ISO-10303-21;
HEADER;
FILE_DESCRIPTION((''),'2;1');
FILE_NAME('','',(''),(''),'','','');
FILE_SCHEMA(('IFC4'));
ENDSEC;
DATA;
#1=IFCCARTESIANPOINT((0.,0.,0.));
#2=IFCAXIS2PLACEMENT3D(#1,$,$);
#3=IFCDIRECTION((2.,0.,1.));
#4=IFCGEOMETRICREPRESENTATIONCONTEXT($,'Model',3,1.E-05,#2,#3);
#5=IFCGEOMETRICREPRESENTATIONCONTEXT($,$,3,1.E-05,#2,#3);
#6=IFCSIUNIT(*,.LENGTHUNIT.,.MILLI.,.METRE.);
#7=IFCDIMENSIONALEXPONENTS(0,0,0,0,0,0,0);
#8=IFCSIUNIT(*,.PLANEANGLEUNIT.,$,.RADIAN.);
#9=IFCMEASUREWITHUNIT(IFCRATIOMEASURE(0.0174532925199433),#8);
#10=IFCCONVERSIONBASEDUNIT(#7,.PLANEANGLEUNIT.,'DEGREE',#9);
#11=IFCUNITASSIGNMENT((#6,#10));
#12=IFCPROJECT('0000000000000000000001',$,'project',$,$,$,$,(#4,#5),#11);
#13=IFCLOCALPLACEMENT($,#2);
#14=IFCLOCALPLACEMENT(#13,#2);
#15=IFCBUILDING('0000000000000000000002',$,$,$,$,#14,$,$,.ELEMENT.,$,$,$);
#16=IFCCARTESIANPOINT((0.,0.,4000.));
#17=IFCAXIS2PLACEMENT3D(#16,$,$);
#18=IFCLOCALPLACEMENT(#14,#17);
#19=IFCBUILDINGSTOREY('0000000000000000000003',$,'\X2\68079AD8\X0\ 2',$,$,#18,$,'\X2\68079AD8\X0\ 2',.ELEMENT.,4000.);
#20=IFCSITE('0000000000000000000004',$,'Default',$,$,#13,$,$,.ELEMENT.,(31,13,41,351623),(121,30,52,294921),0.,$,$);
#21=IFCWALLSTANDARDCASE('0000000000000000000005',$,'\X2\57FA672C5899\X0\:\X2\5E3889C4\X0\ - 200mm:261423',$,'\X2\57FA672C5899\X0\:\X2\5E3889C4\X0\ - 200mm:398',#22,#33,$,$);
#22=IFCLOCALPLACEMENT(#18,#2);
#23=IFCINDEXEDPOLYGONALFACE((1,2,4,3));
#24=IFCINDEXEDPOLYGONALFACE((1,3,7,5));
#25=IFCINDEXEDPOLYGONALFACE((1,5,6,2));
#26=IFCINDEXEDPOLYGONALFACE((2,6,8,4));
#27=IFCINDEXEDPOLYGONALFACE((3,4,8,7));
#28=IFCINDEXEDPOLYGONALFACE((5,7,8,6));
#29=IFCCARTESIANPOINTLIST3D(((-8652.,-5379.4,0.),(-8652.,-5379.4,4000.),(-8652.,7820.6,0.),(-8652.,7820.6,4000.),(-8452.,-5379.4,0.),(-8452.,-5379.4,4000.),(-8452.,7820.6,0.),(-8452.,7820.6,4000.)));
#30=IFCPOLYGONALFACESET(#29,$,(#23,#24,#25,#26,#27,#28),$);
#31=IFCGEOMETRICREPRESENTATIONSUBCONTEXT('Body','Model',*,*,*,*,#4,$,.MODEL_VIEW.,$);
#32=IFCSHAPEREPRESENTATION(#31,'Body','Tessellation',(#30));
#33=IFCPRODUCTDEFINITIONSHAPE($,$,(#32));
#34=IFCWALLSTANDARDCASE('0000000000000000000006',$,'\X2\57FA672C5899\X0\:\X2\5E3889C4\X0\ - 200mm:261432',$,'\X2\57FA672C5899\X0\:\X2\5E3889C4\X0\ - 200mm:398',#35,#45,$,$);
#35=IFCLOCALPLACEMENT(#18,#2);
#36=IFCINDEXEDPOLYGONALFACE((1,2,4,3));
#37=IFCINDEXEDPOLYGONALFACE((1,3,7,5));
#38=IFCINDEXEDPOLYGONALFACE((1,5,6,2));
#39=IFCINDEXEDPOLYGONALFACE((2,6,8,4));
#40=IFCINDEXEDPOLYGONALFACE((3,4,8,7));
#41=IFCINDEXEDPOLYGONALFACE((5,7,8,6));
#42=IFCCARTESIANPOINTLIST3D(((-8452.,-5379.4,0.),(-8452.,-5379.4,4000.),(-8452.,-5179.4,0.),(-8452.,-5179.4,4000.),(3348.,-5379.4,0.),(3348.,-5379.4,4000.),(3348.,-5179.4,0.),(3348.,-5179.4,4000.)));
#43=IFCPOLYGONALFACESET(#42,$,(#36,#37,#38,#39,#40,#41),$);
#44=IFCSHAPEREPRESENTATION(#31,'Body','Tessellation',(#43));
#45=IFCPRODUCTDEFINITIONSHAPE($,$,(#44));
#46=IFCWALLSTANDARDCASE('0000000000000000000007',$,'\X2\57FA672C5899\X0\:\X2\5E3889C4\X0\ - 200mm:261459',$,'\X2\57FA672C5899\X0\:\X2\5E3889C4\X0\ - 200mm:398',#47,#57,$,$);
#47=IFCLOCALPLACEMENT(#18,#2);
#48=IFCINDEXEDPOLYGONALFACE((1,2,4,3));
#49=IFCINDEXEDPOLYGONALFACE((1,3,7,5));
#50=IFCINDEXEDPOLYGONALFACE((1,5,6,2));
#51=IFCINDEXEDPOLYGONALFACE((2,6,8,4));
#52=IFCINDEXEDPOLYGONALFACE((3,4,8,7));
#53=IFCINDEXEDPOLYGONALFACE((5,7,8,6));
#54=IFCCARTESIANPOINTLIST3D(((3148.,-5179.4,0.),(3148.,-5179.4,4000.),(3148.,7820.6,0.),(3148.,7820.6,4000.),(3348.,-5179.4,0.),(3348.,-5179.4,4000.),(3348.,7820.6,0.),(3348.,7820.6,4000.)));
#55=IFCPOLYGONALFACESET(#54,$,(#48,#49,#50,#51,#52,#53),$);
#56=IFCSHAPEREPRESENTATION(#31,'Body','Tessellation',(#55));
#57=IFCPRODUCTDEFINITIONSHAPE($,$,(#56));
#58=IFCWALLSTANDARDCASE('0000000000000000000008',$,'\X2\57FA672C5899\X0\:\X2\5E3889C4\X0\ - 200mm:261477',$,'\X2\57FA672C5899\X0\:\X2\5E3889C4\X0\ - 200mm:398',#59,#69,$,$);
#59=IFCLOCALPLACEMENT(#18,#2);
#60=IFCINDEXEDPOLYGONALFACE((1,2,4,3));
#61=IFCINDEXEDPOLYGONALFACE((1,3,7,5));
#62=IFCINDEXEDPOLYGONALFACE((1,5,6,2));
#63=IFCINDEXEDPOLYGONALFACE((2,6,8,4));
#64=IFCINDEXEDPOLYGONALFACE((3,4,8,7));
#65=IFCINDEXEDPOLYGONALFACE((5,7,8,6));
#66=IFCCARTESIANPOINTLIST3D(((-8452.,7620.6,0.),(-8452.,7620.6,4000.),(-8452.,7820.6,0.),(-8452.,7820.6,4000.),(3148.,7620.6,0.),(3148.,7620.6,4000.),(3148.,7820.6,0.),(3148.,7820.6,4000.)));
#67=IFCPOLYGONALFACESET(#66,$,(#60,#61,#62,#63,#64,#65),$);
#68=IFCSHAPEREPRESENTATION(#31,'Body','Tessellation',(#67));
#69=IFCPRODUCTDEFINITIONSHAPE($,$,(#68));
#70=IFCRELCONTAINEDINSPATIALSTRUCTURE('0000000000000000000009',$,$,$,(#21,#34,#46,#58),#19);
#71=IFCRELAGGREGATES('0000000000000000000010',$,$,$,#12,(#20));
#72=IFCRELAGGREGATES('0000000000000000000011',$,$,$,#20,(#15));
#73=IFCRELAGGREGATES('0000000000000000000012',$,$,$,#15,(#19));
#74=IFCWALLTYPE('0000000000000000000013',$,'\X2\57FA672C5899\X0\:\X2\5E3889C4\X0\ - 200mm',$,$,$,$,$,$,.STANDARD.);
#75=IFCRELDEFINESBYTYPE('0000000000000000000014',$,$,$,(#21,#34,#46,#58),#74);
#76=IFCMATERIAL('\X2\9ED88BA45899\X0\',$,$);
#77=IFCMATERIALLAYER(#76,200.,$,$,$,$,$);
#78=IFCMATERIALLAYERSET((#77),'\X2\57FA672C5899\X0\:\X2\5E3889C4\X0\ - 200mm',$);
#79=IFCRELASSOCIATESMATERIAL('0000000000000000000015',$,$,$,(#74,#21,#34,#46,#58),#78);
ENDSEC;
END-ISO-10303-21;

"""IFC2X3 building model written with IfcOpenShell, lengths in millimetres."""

from ifc_helpers import new_model, entity, si_unit, converted_unit, direction, frame, frame_2d, origin, place, context, subcontext, project, spatial, rectangle, extrude, clip, halfspace, material, layer, layer_set, layer_usage, type_object, element, save


model = new_model("IFC2X3")

# Units and contexts
model_context = context("Model", 3, precision=1e-05, world=origin(), true_north=direction((2.0, 0.0, 1.0)))
context_of_model = context(None, 3, precision=1e-05, world=origin(), true_north=direction((2.0, 0.0, 1.0)))
body_context = subcontext(model_context, "Body", "Model", "MODEL_VIEW")
ifc_project = project(units=[si_unit("LENGTHUNIT", "METRE", prefix="MILLI"), converted_unit("PLANEANGLEUNIT", "DEGREE", entity("IfcRatioMeasure", 0.0174532925199433), si_unit("PLANEANGLEUNIT", "RADIAN"), dimensions=[0, 0, 0, 0, 0, 0, 0])], contexts=[model_context, context_of_model])

# Site, building, storey
site_placement = place(None, frame((0.0, 0.0, 0.0)))
site = spatial("IfcSite", under=ifc_project, at=site_placement, Name="Default", CompositionType="ELEMENT", RefLatitude=(31, 13, 41, 351623), RefLongitude=(121, 30, 52, 294921), RefElevation=0.0)
building_placement = place(site_placement, origin())
building = spatial("IfcBuilding", under=site, at=building_placement, CompositionType="ELEMENT")
storey_placement = place(building_placement, frame((0.0, 0.0, 4000.0)))
storey = spatial("IfcBuildingStorey", under=building, at=storey_placement, Name="标高 2", LongName="标高 2", CompositionType="ELEMENT", Elevation=4000.0)

# Walls
ifc_material = material(Name="默认墙")
ifc_layer = layer(ifc_material, 200.0)
ifc_layer_set = layer_set([ifc_layer], Name="基本墙:常规 - 200mm")
ifc_layer_usage_1 = layer_usage(ifc_layer_set, "AXIS2", "NEGATIVE", 100.0)
wall_type = type_object("IfcWallType", Name="基本墙:常规 - 200mm", PredefinedType="STANDARD", material=ifc_layer_set)
wall_1_placement = place(storey_placement, frame((-8552.0, 7820.6, 0.0), z_axis=(0.0, 0.0, 1.0), x_axis=(0.0, -1.0, 0.0)))
element("IfcWallStandardCase", 1, at=wall_1_placement, inside=storey, type_object=wall_type, material=ifc_layer_usage_1, Name="基本墙:常规 - 200mm:261423", ObjectType="基本墙:常规 - 200mm:398", context=body_context, shape_type="Clipping", body=[
    clip(extrude(rectangle(XDim=13200.0, YDim=200.0, at=frame_2d((6600.0, 0.0), x_axis=(-1.0, 0.0))), origin(), (0.0, 0.0, 1.0), 4000.0), halfspace(frame((0.0, 0.0, -4000.0)), True)),
])
ifc_layer_usage_2 = layer_usage(ifc_layer_set, "AXIS2", "NEGATIVE", 100.0)
wall_2_placement = place(storey_placement, frame((-8452.0, -5279.4, 0.0)))
element("IfcWallStandardCase", 2, at=wall_2_placement, inside=storey, type_object=wall_type, material=ifc_layer_usage_2, Name="基本墙:常规 - 200mm:261432", ObjectType="基本墙:常规 - 200mm:398", context=body_context, shape_type="Clipping", body=[
    clip(extrude(rectangle(XDim=11800.0, YDim=200.0, at=frame_2d((5900.0, 0.0), x_axis=(-1.0, 0.0))), origin(), (0.0, 0.0, 1.0), 4000.0), halfspace(frame((0.0, 0.0, -4000.0)), True)),
])
ifc_layer_usage_3 = layer_usage(ifc_layer_set, "AXIS2", "NEGATIVE", 100.0)
wall_3_placement = place(storey_placement, frame((3248.0, -5179.4, 0.0), z_axis=(0.0, 0.0, 1.0), x_axis=(0.0, 1.0, 0.0)))
element("IfcWallStandardCase", 3, at=wall_3_placement, inside=storey, type_object=wall_type, material=ifc_layer_usage_3, Name="基本墙:常规 - 200mm:261459", ObjectType="基本墙:常规 - 200mm:398", context=body_context, shape_type="Clipping", body=[
    clip(extrude(rectangle(XDim=13000.0, YDim=200.0, at=frame_2d((6500.0, 0.0), x_axis=(-1.0, 0.0))), origin(), (0.0, 0.0, 1.0), 4000.0), halfspace(frame((0.0, 0.0, -4000.0)), True)),
])
ifc_layer_usage_4 = layer_usage(ifc_layer_set, "AXIS2", "NEGATIVE", 100.0)
wall_4_placement = place(storey_placement, frame((3148.0, 7720.6, 0.0), z_axis=(0.0, 0.0, 1.0), x_axis=(-1.0, 0.0, 0.0)))
element("IfcWallStandardCase", 4, at=wall_4_placement, inside=storey, type_object=wall_type, material=ifc_layer_usage_4, Name="基本墙:常规 - 200mm:261477", ObjectType="基本墙:常规 - 200mm:398", context=body_context, shape_type="Clipping", body=[
    clip(extrude(rectangle(XDim=11600.0, YDim=200.0, at=frame_2d((5800.0, 0.0), x_axis=(-1.0, 0.0))), origin(), (0.0, 0.0, 1.0), 4000.0), halfspace(frame((0.0, 0.0, -4000.0)), True)),
])

save(model, "model.ifc")
